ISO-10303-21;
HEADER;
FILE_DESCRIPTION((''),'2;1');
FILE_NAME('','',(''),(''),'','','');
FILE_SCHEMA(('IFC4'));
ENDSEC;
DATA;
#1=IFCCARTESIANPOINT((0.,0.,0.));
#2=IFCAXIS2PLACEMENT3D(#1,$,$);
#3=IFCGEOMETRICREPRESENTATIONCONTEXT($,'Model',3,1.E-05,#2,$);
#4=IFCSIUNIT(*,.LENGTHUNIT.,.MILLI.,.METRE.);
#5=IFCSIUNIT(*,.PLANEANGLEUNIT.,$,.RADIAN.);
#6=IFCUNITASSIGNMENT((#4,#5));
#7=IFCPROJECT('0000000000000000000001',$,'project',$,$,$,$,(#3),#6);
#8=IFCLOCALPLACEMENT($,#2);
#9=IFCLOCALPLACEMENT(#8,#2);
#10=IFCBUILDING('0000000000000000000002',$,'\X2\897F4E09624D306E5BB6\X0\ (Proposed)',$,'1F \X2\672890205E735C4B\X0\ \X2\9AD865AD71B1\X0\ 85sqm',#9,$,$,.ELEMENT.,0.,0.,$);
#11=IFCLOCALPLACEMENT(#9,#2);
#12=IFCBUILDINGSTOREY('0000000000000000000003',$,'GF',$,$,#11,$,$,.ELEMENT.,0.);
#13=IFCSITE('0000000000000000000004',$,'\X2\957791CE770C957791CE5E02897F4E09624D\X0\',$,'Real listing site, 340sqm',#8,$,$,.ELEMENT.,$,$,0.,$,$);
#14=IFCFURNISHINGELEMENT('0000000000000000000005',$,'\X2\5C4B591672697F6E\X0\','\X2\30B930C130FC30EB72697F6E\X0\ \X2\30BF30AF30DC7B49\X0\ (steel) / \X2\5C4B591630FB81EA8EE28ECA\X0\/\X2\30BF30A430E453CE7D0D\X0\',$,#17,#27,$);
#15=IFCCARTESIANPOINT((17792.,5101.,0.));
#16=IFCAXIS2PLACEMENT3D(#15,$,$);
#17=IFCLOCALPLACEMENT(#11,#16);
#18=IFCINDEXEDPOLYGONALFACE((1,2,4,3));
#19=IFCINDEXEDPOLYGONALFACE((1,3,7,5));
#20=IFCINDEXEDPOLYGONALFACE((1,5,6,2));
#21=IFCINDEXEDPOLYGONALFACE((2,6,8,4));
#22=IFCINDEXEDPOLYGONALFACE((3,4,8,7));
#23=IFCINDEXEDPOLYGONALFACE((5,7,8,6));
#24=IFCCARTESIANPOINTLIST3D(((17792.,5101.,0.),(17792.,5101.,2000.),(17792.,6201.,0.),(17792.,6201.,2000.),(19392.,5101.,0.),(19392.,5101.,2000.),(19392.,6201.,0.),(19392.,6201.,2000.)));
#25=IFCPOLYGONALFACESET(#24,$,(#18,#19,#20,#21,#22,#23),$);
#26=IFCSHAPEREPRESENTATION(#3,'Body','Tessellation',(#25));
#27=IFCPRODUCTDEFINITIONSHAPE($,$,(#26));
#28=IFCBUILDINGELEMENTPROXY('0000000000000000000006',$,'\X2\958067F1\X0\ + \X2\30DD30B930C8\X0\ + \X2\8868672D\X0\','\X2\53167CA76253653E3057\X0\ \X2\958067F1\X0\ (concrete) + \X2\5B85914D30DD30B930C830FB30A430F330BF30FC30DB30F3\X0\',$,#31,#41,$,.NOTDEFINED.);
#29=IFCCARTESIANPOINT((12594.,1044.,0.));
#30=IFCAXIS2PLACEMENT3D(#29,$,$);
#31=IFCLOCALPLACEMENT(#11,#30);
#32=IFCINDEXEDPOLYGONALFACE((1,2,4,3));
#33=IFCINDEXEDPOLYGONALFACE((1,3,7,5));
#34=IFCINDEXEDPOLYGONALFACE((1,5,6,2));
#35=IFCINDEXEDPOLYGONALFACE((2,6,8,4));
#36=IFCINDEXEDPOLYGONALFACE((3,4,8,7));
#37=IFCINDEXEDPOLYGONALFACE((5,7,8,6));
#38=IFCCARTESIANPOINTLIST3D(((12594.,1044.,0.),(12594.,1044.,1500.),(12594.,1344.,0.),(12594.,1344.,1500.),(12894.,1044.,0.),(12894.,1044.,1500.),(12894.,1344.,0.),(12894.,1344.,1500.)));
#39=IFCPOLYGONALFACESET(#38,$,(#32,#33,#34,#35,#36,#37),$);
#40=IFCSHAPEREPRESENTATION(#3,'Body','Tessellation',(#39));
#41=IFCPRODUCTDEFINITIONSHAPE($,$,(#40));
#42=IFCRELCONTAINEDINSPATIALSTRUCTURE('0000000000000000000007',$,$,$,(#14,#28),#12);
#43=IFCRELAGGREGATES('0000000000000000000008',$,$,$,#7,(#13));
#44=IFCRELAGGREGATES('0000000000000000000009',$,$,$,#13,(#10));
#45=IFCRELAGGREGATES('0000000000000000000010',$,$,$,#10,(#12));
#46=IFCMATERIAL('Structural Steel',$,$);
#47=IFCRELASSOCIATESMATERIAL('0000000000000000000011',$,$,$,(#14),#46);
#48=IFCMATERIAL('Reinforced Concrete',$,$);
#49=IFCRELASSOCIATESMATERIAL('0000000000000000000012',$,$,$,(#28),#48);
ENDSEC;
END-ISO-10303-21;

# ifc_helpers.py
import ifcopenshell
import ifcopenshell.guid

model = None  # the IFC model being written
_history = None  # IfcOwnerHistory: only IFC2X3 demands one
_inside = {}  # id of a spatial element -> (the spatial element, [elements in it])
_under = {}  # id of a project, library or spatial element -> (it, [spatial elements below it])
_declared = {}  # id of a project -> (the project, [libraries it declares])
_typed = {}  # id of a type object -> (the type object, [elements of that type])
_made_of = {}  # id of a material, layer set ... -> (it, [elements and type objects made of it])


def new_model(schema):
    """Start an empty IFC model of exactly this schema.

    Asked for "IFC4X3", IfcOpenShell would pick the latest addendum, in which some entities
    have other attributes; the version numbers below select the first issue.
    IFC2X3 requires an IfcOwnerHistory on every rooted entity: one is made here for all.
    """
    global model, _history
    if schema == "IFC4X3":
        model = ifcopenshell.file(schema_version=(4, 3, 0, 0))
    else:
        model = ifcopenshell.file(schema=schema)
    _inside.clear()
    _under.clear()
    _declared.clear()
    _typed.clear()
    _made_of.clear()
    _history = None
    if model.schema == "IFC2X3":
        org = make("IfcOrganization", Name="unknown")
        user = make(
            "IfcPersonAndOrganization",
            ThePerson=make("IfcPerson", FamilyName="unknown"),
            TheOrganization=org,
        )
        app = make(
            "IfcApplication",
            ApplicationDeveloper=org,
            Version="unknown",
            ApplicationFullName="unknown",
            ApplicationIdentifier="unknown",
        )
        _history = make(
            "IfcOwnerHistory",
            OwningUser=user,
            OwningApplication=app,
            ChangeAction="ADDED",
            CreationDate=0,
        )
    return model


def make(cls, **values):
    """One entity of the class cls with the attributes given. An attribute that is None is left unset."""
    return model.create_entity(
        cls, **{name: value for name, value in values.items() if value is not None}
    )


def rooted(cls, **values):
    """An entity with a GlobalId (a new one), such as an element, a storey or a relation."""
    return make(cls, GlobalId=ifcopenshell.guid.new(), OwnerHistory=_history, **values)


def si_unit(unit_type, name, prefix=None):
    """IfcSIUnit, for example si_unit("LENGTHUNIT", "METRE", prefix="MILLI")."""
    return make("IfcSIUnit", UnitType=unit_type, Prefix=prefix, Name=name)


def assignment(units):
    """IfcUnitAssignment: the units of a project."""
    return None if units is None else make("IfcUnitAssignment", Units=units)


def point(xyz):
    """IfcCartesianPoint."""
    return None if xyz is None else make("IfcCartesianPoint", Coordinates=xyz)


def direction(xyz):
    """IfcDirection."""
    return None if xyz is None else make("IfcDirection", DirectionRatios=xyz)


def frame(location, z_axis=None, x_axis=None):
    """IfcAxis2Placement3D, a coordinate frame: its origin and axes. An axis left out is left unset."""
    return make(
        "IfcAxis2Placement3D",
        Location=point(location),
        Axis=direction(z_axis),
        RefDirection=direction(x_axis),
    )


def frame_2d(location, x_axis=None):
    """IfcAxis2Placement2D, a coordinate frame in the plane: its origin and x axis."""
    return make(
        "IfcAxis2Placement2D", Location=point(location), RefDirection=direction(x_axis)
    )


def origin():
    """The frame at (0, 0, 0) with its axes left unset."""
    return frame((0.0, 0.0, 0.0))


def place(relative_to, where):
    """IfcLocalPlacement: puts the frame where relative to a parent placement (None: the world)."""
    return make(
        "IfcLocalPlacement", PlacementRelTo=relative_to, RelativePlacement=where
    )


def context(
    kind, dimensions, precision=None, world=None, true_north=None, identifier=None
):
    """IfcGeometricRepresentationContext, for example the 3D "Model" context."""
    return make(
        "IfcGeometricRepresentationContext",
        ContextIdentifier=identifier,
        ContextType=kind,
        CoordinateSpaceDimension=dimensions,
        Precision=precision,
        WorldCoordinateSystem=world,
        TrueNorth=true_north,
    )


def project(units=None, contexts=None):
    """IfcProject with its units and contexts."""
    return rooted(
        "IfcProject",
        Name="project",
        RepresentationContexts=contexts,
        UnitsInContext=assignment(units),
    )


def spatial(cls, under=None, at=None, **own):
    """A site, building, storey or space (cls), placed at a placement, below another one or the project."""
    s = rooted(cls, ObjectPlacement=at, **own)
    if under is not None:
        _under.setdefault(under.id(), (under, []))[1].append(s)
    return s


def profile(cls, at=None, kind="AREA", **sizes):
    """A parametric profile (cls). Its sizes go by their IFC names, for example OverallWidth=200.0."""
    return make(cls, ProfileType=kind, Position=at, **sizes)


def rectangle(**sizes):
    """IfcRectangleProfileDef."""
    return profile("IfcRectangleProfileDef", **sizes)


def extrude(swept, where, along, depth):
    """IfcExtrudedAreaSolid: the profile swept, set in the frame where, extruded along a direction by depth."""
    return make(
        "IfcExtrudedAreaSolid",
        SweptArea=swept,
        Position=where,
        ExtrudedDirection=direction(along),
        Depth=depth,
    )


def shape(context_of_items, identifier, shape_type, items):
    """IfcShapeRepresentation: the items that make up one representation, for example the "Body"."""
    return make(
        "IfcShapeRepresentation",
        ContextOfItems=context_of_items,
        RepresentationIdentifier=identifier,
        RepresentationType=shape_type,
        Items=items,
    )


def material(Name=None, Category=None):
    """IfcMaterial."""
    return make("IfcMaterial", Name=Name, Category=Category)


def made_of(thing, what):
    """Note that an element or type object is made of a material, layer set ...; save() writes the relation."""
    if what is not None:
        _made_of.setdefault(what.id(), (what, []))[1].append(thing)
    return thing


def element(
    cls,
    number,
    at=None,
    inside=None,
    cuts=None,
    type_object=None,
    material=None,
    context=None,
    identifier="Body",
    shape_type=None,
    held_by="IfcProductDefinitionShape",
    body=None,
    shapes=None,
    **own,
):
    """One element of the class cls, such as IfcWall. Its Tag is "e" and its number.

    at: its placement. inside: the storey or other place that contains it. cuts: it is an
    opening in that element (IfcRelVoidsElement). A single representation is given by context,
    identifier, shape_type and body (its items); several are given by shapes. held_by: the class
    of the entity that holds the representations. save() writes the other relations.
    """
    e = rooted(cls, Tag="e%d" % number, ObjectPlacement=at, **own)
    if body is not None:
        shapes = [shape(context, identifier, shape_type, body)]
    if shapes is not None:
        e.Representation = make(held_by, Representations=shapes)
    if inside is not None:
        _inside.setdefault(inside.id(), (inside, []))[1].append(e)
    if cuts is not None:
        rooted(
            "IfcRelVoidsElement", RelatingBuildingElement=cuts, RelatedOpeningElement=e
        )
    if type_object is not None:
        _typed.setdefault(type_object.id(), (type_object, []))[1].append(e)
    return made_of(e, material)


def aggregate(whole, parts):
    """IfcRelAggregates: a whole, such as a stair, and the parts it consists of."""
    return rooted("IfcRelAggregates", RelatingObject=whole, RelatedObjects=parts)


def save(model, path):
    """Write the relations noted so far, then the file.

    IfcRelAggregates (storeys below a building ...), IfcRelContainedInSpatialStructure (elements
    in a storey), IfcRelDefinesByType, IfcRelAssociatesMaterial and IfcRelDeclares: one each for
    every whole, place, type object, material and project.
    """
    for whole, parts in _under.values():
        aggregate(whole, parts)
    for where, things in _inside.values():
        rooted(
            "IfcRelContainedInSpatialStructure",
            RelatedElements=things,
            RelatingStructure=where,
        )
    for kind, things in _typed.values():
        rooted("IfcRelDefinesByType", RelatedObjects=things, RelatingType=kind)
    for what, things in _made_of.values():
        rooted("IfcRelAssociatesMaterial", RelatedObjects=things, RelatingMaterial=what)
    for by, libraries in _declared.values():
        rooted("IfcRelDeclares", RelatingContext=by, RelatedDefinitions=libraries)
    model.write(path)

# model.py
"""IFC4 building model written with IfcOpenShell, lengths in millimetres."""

from ifc_helpers import new_model, si_unit, frame, frame_2d, origin, place, context, project, spatial, rectangle, extrude, material, element, save


model = new_model("IFC4")

# Units and contexts
model_context = context("Model", 3, precision=1e-05, world=origin())
ifc_project = project(units=[si_unit("LENGTHUNIT", "METRE", prefix="MILLI"), si_unit("PLANEANGLEUNIT", "RADIAN")], contexts=[model_context])

# Site, building, storey
site_placement = place(None, origin())
site = spatial("IfcSite", under=ifc_project, at=site_placement, Name="長野県長野市西三才", ObjectType="Real listing site, 340sqm", CompositionType="ELEMENT", RefElevation=0.0)
building_placement = place(site_placement, origin())
building = spatial("IfcBuilding", under=site, at=building_placement, Name="西三才の家 (Proposed)", ObjectType="1F 木造平屋 高断熱 85sqm", CompositionType="ELEMENT", ElevationOfRefHeight=0.0, ElevationOfTerrain=0.0)
storey_placement = place(building_placement, origin())
storey = spatial("IfcBuildingStorey", under=building, at=storey_placement, Name="GF", CompositionType="ELEMENT", Elevation=0.0)

# Shared definitions
ifc_material_1 = material(Name="Structural Steel")

# Shared definitions
ifc_material_2 = material(Name="Reinforced Concrete")

# Furnishing element
furnishing_1_placement = place(storey_placement, frame((17792.0, 5101.0, 0.0)))
element("IfcFurnishingElement", 1, at=furnishing_1_placement, inside=storey, material=ifc_material_1, Name="屋外物置", Description="スチール物置 タクボ等 (steel) / 屋外・自転車/タイヤ収納", context=model_context, shape_type="SweptSolid", body=[
    extrude(rectangle(XDim=1600.0, YDim=1100.0, at=frame_2d((800.0, 550.0))), frame((17792.0, 5101.0, 0.0)), (0.0, 0.0, 1.0), 2000.0),
])

# Building element proxy
proxy_placement = place(storey_placement, frame((12594.0, 1044.0, 0.0)))
element("IfcBuildingElementProxy", 2, at=proxy_placement, inside=storey, material=ifc_material_2, Name="門柱 + ポスト + 表札", Description="化粧打放し 門柱 (concrete) + 宅配ポスト・インターホン", PredefinedType="NOTDEFINED", context=model_context, shape_type="SweptSolid", body=[
    extrude(rectangle(XDim=300.0, YDim=300.0, at=frame_2d((150.0, 150.0))), frame((12594.0, 1044.0, 0.0)), (0.0, 0.0, 1.0), 1500.0),
])

save(model, "model.ifc")
